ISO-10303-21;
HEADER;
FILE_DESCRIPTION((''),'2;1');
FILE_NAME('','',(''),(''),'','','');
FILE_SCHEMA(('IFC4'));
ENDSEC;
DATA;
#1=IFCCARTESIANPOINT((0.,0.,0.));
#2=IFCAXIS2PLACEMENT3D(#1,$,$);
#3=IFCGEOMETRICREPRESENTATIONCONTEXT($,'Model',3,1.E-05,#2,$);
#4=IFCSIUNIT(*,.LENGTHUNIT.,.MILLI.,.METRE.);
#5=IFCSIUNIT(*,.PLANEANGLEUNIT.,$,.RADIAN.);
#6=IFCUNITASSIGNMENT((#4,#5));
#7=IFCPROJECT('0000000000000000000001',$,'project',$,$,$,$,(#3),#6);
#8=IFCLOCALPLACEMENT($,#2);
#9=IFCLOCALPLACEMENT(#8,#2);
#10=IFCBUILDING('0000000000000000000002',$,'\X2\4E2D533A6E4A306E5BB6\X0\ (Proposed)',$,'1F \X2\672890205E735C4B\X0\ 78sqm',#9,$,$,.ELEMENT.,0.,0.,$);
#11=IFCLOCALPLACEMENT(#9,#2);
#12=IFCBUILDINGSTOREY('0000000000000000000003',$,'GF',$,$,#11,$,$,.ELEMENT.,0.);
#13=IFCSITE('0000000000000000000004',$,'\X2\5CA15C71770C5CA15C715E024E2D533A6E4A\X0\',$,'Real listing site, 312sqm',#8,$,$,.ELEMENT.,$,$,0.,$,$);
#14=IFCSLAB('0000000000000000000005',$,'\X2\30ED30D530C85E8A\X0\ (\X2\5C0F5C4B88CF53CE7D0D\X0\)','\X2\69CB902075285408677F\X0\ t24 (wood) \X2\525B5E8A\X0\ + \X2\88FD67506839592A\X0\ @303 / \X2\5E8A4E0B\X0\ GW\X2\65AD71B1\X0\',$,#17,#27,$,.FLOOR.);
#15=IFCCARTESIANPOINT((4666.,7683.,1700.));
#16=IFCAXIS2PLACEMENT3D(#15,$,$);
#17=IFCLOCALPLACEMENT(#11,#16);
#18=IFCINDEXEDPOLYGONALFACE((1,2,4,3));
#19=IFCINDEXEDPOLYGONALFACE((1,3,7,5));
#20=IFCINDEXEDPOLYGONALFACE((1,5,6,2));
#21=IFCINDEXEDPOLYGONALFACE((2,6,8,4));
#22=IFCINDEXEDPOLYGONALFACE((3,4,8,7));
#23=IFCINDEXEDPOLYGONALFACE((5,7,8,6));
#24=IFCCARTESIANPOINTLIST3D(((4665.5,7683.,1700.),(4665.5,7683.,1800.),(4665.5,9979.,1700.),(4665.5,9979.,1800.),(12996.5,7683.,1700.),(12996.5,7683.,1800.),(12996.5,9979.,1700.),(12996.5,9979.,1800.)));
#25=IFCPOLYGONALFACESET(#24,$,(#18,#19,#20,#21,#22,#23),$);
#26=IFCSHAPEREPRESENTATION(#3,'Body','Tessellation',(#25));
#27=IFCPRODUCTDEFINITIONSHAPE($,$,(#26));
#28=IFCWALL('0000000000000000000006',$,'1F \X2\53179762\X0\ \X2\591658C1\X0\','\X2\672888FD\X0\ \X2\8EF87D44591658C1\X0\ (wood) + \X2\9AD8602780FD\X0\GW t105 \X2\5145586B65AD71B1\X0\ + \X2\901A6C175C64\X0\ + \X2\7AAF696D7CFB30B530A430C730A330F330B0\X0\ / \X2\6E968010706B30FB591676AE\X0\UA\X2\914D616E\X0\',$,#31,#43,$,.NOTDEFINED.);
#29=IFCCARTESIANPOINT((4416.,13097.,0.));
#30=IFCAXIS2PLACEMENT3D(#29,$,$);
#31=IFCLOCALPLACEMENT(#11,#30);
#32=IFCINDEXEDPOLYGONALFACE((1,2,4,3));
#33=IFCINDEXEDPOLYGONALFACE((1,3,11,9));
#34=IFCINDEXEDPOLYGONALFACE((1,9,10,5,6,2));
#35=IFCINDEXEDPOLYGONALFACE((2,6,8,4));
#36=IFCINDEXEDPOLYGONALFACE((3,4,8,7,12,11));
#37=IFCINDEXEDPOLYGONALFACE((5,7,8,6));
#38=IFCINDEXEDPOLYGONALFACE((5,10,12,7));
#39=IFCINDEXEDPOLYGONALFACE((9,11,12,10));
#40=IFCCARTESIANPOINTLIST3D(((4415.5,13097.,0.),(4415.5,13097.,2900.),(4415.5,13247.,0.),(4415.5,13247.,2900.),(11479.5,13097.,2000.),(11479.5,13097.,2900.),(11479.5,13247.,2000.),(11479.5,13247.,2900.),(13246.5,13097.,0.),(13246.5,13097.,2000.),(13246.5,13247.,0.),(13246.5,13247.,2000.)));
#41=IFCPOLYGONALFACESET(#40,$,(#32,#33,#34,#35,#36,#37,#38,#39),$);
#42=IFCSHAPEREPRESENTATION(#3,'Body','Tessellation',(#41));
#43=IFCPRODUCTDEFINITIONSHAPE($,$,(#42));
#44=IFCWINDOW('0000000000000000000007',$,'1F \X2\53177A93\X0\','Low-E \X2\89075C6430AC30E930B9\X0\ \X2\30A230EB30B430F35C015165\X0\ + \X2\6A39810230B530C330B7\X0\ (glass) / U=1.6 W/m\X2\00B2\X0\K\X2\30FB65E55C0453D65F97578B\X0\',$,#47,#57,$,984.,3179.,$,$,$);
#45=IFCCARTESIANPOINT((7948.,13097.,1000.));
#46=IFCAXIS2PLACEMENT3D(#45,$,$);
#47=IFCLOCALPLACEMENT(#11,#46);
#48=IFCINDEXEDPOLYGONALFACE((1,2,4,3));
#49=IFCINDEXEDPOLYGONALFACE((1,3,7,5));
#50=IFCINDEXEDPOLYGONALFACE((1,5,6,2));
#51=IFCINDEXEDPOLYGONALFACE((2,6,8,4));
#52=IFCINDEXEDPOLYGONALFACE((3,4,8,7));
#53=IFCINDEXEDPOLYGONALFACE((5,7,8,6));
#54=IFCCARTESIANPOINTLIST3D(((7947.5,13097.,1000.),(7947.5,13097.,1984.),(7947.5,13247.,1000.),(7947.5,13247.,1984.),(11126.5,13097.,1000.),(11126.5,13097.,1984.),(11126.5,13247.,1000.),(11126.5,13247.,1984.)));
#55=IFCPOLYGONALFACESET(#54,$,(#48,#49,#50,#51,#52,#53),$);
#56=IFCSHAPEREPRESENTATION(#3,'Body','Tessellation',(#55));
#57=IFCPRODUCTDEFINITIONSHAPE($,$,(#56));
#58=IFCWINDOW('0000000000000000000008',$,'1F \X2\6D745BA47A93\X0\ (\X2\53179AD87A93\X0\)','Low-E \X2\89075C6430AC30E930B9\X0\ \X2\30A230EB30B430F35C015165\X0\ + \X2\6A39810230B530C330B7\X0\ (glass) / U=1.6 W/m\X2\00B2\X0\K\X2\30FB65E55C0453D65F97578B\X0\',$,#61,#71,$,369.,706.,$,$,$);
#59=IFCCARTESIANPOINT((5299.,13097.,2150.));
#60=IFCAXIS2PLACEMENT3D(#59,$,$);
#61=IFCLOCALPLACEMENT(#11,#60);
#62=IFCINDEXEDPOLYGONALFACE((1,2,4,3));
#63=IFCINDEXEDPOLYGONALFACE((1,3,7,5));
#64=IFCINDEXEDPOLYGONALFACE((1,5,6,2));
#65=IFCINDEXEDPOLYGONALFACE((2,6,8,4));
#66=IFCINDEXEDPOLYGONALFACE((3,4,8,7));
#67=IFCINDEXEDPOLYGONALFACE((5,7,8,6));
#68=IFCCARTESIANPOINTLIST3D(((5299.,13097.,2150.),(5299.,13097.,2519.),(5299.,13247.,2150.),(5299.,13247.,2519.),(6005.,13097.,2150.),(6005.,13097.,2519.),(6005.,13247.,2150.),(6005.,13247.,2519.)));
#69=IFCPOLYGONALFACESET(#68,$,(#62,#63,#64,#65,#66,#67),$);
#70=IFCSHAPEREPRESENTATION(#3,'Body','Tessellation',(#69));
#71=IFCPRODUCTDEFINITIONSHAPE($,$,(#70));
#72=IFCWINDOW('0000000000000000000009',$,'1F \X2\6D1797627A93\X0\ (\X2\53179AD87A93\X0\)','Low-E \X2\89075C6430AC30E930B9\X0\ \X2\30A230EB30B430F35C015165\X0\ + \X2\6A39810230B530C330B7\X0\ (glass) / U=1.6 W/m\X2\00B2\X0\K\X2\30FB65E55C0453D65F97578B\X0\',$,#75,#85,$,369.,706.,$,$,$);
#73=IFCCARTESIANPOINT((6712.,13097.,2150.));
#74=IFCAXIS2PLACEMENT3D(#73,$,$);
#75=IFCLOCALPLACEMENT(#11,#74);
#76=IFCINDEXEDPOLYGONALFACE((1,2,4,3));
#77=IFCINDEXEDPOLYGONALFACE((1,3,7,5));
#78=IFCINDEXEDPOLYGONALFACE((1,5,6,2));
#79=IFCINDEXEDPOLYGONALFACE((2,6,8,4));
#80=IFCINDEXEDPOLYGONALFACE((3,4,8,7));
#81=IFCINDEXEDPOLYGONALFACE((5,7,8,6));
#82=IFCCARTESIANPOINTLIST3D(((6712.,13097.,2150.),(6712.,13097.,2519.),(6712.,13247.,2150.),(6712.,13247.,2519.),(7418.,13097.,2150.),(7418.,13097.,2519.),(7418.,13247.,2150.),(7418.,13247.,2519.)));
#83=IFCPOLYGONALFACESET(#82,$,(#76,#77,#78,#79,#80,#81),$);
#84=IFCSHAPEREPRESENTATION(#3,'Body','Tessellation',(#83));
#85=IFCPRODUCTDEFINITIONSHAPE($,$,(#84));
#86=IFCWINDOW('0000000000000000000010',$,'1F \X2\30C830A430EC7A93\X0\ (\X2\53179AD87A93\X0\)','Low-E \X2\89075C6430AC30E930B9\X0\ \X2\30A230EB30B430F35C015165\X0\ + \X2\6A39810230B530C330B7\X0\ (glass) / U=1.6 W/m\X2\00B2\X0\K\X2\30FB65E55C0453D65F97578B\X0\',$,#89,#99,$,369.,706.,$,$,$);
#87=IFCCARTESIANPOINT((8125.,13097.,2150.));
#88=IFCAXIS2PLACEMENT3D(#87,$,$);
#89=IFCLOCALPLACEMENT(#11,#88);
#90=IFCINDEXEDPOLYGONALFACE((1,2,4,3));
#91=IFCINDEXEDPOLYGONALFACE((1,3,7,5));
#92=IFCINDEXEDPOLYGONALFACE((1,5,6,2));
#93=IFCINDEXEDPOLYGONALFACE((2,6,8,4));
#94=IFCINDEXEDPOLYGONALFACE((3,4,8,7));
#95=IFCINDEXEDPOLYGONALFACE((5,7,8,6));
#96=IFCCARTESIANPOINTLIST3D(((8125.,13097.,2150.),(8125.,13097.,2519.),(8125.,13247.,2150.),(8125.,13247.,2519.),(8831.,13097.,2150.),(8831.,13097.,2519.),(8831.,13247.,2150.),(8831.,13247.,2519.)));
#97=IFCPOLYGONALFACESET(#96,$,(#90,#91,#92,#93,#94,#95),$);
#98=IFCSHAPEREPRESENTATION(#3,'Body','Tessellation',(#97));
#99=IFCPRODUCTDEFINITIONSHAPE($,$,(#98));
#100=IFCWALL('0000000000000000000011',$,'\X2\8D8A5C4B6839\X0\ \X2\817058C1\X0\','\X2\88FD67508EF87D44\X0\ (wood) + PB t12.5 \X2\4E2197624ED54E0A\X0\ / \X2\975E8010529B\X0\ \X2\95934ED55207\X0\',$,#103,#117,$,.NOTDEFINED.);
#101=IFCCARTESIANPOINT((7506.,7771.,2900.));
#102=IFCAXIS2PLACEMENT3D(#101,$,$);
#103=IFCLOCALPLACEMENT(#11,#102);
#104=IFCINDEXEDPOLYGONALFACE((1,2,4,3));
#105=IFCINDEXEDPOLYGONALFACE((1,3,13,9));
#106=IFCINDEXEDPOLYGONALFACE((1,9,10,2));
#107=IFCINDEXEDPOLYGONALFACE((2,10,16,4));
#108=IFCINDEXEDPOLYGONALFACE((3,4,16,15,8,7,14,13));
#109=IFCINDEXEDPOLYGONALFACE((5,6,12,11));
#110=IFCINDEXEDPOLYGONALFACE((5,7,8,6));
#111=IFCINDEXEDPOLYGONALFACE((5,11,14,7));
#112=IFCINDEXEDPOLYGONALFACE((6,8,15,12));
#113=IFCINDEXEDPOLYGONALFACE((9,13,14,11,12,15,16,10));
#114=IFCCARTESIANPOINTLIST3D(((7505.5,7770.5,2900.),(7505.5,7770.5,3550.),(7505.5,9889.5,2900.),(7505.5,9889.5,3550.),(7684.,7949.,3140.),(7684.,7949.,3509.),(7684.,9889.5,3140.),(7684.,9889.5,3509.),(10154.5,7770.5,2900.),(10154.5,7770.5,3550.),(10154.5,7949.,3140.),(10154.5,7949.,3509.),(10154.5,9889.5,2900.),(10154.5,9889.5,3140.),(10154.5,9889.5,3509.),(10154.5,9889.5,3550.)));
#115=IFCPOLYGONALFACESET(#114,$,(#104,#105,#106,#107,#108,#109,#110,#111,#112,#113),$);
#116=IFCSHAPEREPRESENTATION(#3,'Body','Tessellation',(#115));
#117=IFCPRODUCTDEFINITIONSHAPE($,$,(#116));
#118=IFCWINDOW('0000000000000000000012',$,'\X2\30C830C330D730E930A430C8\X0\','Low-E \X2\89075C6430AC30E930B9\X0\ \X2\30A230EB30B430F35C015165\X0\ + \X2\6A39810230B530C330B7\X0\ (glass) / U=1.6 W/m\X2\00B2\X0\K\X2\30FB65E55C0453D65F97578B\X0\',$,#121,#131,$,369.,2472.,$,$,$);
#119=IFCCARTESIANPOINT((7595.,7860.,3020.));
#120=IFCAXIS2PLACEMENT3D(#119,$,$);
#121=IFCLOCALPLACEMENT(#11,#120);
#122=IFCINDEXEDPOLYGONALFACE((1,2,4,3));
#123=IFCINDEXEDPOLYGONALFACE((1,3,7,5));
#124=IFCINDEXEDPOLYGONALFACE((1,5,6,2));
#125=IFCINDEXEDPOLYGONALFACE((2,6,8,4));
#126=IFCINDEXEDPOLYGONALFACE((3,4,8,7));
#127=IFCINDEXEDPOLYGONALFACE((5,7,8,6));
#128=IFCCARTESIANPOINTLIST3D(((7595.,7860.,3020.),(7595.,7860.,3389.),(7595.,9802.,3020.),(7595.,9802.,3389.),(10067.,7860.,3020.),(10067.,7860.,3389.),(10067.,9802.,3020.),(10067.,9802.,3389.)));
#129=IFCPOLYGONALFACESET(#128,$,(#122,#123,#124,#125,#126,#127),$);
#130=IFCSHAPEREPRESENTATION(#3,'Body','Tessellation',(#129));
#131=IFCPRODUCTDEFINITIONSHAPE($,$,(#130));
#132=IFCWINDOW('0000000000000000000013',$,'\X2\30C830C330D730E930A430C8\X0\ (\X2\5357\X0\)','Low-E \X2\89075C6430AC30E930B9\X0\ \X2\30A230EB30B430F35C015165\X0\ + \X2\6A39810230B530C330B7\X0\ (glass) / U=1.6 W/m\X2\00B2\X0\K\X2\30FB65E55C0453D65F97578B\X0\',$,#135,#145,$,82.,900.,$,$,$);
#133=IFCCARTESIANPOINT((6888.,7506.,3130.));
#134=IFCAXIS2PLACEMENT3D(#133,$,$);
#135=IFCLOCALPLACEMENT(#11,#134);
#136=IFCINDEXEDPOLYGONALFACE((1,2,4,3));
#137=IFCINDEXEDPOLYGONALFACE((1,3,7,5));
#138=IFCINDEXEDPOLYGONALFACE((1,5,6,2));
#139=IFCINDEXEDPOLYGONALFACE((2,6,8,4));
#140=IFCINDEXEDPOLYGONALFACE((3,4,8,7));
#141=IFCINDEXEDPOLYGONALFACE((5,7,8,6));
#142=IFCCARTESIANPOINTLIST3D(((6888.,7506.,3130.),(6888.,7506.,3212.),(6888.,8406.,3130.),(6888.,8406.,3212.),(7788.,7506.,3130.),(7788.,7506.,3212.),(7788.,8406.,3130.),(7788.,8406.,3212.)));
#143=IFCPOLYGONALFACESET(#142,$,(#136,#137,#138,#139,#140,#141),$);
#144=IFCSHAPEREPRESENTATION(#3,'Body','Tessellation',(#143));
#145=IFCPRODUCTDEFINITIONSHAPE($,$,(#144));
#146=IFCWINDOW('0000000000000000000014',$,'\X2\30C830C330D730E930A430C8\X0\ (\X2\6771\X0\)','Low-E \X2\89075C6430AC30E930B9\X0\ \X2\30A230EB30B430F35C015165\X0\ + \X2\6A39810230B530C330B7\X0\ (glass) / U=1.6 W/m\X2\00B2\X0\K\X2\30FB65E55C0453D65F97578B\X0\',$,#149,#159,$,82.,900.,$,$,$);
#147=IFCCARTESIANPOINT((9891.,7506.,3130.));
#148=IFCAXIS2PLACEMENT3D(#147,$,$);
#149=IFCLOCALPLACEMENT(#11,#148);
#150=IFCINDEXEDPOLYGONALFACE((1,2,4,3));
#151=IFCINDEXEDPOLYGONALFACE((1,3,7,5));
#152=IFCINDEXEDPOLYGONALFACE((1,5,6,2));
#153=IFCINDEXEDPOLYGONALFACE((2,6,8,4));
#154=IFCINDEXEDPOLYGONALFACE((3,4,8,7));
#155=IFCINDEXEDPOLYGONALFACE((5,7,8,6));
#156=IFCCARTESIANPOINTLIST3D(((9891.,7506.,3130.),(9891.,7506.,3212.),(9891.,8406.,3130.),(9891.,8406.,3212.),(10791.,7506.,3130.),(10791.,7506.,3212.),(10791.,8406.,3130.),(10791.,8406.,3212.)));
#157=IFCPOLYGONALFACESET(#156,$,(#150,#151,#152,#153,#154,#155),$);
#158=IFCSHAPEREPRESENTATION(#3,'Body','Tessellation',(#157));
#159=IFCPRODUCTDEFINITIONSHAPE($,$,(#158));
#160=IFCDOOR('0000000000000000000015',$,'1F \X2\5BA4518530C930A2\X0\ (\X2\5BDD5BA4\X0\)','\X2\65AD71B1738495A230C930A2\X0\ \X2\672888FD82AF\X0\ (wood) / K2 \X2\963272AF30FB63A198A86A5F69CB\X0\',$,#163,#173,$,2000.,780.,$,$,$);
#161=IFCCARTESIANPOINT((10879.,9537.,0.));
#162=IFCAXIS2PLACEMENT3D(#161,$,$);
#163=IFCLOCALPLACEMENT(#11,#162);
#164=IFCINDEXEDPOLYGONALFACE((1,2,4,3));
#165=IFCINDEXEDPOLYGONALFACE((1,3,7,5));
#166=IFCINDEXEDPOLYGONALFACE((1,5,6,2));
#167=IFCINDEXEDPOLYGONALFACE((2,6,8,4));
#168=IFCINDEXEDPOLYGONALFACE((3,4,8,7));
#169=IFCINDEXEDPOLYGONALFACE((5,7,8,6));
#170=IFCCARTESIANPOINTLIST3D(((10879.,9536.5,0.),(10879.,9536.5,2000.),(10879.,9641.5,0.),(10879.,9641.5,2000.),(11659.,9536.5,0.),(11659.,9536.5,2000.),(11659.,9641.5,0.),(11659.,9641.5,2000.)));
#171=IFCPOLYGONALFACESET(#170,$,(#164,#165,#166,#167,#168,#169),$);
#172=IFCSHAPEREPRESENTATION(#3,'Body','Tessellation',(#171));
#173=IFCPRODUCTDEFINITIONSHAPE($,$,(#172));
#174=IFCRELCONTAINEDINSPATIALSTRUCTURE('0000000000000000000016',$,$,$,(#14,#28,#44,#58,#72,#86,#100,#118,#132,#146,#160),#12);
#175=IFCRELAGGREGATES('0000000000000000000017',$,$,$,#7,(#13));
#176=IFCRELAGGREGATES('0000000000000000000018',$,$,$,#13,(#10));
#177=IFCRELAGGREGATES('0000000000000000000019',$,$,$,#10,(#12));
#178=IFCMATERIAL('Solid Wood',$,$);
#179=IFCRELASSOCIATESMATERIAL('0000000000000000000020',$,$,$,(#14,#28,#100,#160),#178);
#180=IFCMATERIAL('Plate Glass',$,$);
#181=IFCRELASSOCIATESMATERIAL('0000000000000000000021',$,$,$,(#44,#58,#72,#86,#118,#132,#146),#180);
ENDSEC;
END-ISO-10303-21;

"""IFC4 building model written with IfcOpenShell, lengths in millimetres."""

from ifc_helpers import new_model, si_unit, frame, frame_2d, origin, place, context, project, spatial, rectangle, extrude, material, element, fill, save


model = new_model("IFC4")

# Units and contexts
model_context = context("Model", 3, precision=1e-05, world=origin())
ifc_project = project(units=[si_unit("LENGTHUNIT", "METRE", prefix="MILLI"), si_unit("PLANEANGLEUNIT", "RADIAN")], contexts=[model_context])

# Site, building, storey
site_placement = place(None, origin())
site = spatial("IfcSite", under=ifc_project, at=site_placement, Name="岡山県岡山市中区湊", ObjectType="Real listing site, 312sqm", CompositionType="ELEMENT", RefElevation=0.0)
building_placement = place(site_placement, origin())
building = spatial("IfcBuilding", under=site, at=building_placement, Name="中区湊の家 (Proposed)", ObjectType="1F 木造平屋 78sqm", CompositionType="ELEMENT", ElevationOfRefHeight=0.0, ElevationOfTerrain=0.0)
storey_placement = place(building_placement, origin())
storey = spatial("IfcBuildingStorey", under=building, at=storey_placement, Name="GF", CompositionType="ELEMENT", Elevation=0.0)

# Slab
ifc_material_1 = material(Name="Solid Wood")
slab_placement = place(storey_placement, frame((4666.0, 7683.0, 1700.0)))
element("IfcSlab", 1, at=slab_placement, inside=storey, material=ifc_material_1, Name="ロフト床 (小屋裏収納)", Description="構造用合板 t24 (wood) 剛床 + 製材根太 @303 / 床下 GW断熱", PredefinedType="FLOOR", context=model_context, shape_type="SweptSolid", body=[
    extrude(rectangle(XDim=8331.0, YDim=2296.0, at=frame_2d((4165.0, 1148.0))), frame((4666.0, 7683.0, 1700.0)), (0.0, 0.0, 1.0), 100.0),
])

# Wall, openings, windows
wall_1_placement = place(storey_placement, frame((4416.0, 13097.0, 0.0)))
wall_1 = element("IfcWall", 2, at=wall_1_placement, inside=storey, material=ifc_material_1, Name="1F 北面 外壁", Description="木製 軸組外壁 (wood) + 高性能GW t105 充填断熱 + 通気層 + 窯業系サイディング / 準耐火・外皮UA配慮", PredefinedType="NOTDEFINED", context=model_context, shape_type="SweptSolid", body=[
    extrude(rectangle(XDim=8831.0, YDim=150.0, at=frame_2d((4415.0, 75.0))), frame((4416.0, 13097.0, 0.0)), (0.0, 0.0, 1.0), 2900.0),
])
opening_1_placement = place(storey_placement, frame((7948.0, 13097.0, 1000.0)))
opening_1 = element("IfcOpeningElement", 3, at=opening_1_placement, cuts=wall_1, PredefinedType="NOTDEFINED", context=model_context, shape_type="SweptSolid", body=[
    extrude(rectangle(XDim=3179.0, YDim=150.0, at=frame_2d((1589.0, 75.0))), frame((7948.0, 13097.0, 1000.0)), (0.0, 0.0, 1.0), 984.0),
])
opening_2_placement = place(storey_placement, frame((5299.0, 13097.0, 2150.0)))
opening_2 = element("IfcOpeningElement", 4, at=opening_2_placement, cuts=wall_1, PredefinedType="NOTDEFINED", context=model_context, shape_type="SweptSolid", body=[
    extrude(rectangle(XDim=706.0, YDim=150.0, at=frame_2d((353.0, 75.0))), frame((5299.0, 13097.0, 2150.0)), (0.0, 0.0, 1.0), 369.0),
])
opening_3_placement = place(storey_placement, frame((6712.0, 13097.0, 2150.0)))
opening_3 = element("IfcOpeningElement", 5, at=opening_3_placement, cuts=wall_1, PredefinedType="NOTDEFINED", context=model_context, shape_type="SweptSolid", body=[
    extrude(rectangle(XDim=706.0, YDim=150.0, at=frame_2d((353.0, 75.0))), frame((6712.0, 13097.0, 2150.0)), (0.0, 0.0, 1.0), 369.0),
])
opening_4_placement = place(storey_placement, frame((8125.0, 13097.0, 2150.0)))
opening_4 = element("IfcOpeningElement", 6, at=opening_4_placement, cuts=wall_1, PredefinedType="NOTDEFINED", context=model_context, shape_type="SweptSolid", body=[
    extrude(rectangle(XDim=706.0, YDim=150.0, at=frame_2d((353.0, 75.0))), frame((8125.0, 13097.0, 2150.0)), (0.0, 0.0, 1.0), 369.0),
])
ifc_material_2 = material(Name="Plate Glass")
window_1_placement = place(storey_placement, frame((7948.0, 13097.0, 1000.0)))
window_1 = element("IfcWindow", 7, at=window_1_placement, inside=storey, material=ifc_material_2, Name="1F 北窓", Description="Low-E 複層ガラス アルゴン封入 + 樹脂サッシ (glass) / U=1.6 W/m²K・日射取得型", OverallHeight=984.0, OverallWidth=3179.0, context=model_context, shape_type="SweptSolid", body=[
    extrude(rectangle(XDim=3179.0, YDim=150.0, at=frame_2d((1589.0, 75.0))), frame((7948.0, 13097.0, 1000.0)), (0.0, 0.0, 1.0), 984.0),
])
fill(opening_1, window_1)
window_2_placement = place(storey_placement, frame((5299.0, 13097.0, 2150.0)))
window_2 = element("IfcWindow", 8, at=window_2_placement, inside=storey, material=ifc_material_2, Name="1F 浴室窓 (北高窓)", Description="Low-E 複層ガラス アルゴン封入 + 樹脂サッシ (glass) / U=1.6 W/m²K・日射取得型", OverallHeight=369.0, OverallWidth=706.0, context=model_context, shape_type="SweptSolid", body=[
    extrude(rectangle(XDim=706.0, YDim=150.0, at=frame_2d((353.0, 75.0))), frame((5299.0, 13097.0, 2150.0)), (0.0, 0.0, 1.0), 369.0),
])
fill(opening_2, window_2)
window_3_placement = place(storey_placement, frame((6712.0, 13097.0, 2150.0)))
window_3 = element("IfcWindow", 9, at=window_3_placement, inside=storey, material=ifc_material_2, Name="1F 洗面窓 (北高窓)", Description="Low-E 複層ガラス アルゴン封入 + 樹脂サッシ (glass) / U=1.6 W/m²K・日射取得型", OverallHeight=369.0, OverallWidth=706.0, context=model_context, shape_type="SweptSolid", body=[
    extrude(rectangle(XDim=706.0, YDim=150.0, at=frame_2d((353.0, 75.0))), frame((6712.0, 13097.0, 2150.0)), (0.0, 0.0, 1.0), 369.0),
])
fill(opening_3, window_3)
window_4_placement = place(storey_placement, frame((8125.0, 13097.0, 2150.0)))
window_4 = element("IfcWindow", 10, at=window_4_placement, inside=storey, material=ifc_material_2, Name="1F トイレ窓 (北高窓)", Description="Low-E 複層ガラス アルゴン封入 + 樹脂サッシ (glass) / U=1.6 W/m²K・日射取得型", OverallHeight=369.0, OverallWidth=706.0, context=model_context, shape_type="SweptSolid", body=[
    extrude(rectangle(XDim=706.0, YDim=150.0, at=frame_2d((353.0, 75.0))), frame((8125.0, 13097.0, 2150.0)), (0.0, 0.0, 1.0), 369.0),
])
fill(opening_4, window_4)

# Wall, openings, windows
wall_2_placement = place(storey_placement, frame((7506.0, 7771.0, 2900.0)))
wall_2 = element("IfcWall", 11, at=wall_2_placement, inside=storey, material=ifc_material_1, Name="越屋根 腰壁", Description="製材軸組 (wood) + PB t12.5 両面仕上 / 非耐力 間仕切", PredefinedType="NOTDEFINED", context=model_context, shape_type="SweptSolid", body=[
    extrude(rectangle(XDim=2649.0, YDim=2119.0, at=frame_2d((1324.0, 1059.0))), frame((7506.0, 7771.0, 2900.0)), (0.0, 0.0, 1.0), 650.0),
])
opening_5_placement = place(storey_placement, frame((7595.0, 7860.0, 3020.0)))
opening_5 = element("IfcOpeningElement", 12, at=opening_5_placement, cuts=wall_2, PredefinedType="NOTDEFINED", context=model_context, shape_type="SweptSolid", body=[
    extrude(rectangle(XDim=2472.0, YDim=1942.0, at=frame_2d((1236.0, 971.0))), frame((7595.0, 7860.0, 3020.0)), (0.0, 0.0, 1.0), 369.0),
])
opening_6_placement = place(storey_placement, frame((6888.0, 7506.0, 3130.0)))
opening_6 = element("IfcOpeningElement", 13, at=opening_6_placement, cuts=wall_2, PredefinedType="NOTDEFINED", context=model_context, shape_type="SweptSolid", body=[
    extrude(rectangle(XDim=900.0, YDim=900.0, at=frame_2d((450.0, 450.0))), frame((6888.0, 7506.0, 3130.0)), (0.0, 0.0, 1.0), 82.0),
])
opening_7_placement = place(storey_placement, frame((9891.0, 7506.0, 3130.0)))
opening_7 = element("IfcOpeningElement", 14, at=opening_7_placement, cuts=wall_2, PredefinedType="NOTDEFINED", context=model_context, shape_type="SweptSolid", body=[
    extrude(rectangle(XDim=900.0, YDim=900.0, at=frame_2d((450.0, 450.0))), frame((9891.0, 7506.0, 3130.0)), (0.0, 0.0, 1.0), 82.0),
])
window_5_placement = place(storey_placement, frame((7595.0, 7860.0, 3020.0)))
window_5 = element("IfcWindow", 15, at=window_5_placement, inside=storey, material=ifc_material_2, Name="トップライト", Description="Low-E 複層ガラス アルゴン封入 + 樹脂サッシ (glass) / U=1.6 W/m²K・日射取得型", OverallHeight=369.0, OverallWidth=2472.0, context=model_context, shape_type="SweptSolid", body=[
    extrude(rectangle(XDim=2472.0, YDim=1942.0, at=frame_2d((1236.0, 971.0))), frame((7595.0, 7860.0, 3020.0)), (0.0, 0.0, 1.0), 369.0),
])
fill(opening_5, window_5)
window_6_placement = place(storey_placement, frame((6888.0, 7506.0, 3130.0)))
window_6 = element("IfcWindow", 16, at=window_6_placement, inside=storey, material=ifc_material_2, Name="トップライト (南)", Description="Low-E 複層ガラス アルゴン封入 + 樹脂サッシ (glass) / U=1.6 W/m²K・日射取得型", OverallHeight=82.0, OverallWidth=900.0, context=model_context, shape_type="SweptSolid", body=[
    extrude(rectangle(XDim=900.0, YDim=900.0, at=frame_2d((450.0, 450.0))), frame((6888.0, 7506.0, 3130.0)), (0.0, 0.0, 1.0), 82.0),
])
fill(opening_6, window_6)
window_7_placement = place(storey_placement, frame((9891.0, 7506.0, 3130.0)))
window_7 = element("IfcWindow", 17, at=window_7_placement, inside=storey, material=ifc_material_2, Name="トップライト (東)", Description="Low-E 複層ガラス アルゴン封入 + 樹脂サッシ (glass) / U=1.6 W/m²K・日射取得型", OverallHeight=82.0, OverallWidth=900.0, context=model_context, shape_type="SweptSolid", body=[
    extrude(rectangle(XDim=900.0, YDim=900.0, at=frame_2d((450.0, 450.0))), frame((9891.0, 7506.0, 3130.0)), (0.0, 0.0, 1.0), 82.0),
])
fill(opening_7, window_7)

# Door
door_1_placement = place(storey_placement, frame((10879.0, 9537.0, 0.0)))
element("IfcDoor", 18, at=door_1_placement, inside=storey, material=ifc_material_1, Name="1F 室内ドア (寝室)", Description="断熱玄関ドア 木製芯 (wood) / K2 防犯・採風機構", OverallHeight=2000.0, OverallWidth=780.0, context=model_context, shape_type="SweptSolid", body=[
    extrude(rectangle(XDim=780.0, YDim=105.0, at=frame_2d((390.0, 52.0))), frame((10879.0, 9537.0, 0.0)), (0.0, 0.0, 1.0), 2000.0),
])

save(model, "model.ifc")
